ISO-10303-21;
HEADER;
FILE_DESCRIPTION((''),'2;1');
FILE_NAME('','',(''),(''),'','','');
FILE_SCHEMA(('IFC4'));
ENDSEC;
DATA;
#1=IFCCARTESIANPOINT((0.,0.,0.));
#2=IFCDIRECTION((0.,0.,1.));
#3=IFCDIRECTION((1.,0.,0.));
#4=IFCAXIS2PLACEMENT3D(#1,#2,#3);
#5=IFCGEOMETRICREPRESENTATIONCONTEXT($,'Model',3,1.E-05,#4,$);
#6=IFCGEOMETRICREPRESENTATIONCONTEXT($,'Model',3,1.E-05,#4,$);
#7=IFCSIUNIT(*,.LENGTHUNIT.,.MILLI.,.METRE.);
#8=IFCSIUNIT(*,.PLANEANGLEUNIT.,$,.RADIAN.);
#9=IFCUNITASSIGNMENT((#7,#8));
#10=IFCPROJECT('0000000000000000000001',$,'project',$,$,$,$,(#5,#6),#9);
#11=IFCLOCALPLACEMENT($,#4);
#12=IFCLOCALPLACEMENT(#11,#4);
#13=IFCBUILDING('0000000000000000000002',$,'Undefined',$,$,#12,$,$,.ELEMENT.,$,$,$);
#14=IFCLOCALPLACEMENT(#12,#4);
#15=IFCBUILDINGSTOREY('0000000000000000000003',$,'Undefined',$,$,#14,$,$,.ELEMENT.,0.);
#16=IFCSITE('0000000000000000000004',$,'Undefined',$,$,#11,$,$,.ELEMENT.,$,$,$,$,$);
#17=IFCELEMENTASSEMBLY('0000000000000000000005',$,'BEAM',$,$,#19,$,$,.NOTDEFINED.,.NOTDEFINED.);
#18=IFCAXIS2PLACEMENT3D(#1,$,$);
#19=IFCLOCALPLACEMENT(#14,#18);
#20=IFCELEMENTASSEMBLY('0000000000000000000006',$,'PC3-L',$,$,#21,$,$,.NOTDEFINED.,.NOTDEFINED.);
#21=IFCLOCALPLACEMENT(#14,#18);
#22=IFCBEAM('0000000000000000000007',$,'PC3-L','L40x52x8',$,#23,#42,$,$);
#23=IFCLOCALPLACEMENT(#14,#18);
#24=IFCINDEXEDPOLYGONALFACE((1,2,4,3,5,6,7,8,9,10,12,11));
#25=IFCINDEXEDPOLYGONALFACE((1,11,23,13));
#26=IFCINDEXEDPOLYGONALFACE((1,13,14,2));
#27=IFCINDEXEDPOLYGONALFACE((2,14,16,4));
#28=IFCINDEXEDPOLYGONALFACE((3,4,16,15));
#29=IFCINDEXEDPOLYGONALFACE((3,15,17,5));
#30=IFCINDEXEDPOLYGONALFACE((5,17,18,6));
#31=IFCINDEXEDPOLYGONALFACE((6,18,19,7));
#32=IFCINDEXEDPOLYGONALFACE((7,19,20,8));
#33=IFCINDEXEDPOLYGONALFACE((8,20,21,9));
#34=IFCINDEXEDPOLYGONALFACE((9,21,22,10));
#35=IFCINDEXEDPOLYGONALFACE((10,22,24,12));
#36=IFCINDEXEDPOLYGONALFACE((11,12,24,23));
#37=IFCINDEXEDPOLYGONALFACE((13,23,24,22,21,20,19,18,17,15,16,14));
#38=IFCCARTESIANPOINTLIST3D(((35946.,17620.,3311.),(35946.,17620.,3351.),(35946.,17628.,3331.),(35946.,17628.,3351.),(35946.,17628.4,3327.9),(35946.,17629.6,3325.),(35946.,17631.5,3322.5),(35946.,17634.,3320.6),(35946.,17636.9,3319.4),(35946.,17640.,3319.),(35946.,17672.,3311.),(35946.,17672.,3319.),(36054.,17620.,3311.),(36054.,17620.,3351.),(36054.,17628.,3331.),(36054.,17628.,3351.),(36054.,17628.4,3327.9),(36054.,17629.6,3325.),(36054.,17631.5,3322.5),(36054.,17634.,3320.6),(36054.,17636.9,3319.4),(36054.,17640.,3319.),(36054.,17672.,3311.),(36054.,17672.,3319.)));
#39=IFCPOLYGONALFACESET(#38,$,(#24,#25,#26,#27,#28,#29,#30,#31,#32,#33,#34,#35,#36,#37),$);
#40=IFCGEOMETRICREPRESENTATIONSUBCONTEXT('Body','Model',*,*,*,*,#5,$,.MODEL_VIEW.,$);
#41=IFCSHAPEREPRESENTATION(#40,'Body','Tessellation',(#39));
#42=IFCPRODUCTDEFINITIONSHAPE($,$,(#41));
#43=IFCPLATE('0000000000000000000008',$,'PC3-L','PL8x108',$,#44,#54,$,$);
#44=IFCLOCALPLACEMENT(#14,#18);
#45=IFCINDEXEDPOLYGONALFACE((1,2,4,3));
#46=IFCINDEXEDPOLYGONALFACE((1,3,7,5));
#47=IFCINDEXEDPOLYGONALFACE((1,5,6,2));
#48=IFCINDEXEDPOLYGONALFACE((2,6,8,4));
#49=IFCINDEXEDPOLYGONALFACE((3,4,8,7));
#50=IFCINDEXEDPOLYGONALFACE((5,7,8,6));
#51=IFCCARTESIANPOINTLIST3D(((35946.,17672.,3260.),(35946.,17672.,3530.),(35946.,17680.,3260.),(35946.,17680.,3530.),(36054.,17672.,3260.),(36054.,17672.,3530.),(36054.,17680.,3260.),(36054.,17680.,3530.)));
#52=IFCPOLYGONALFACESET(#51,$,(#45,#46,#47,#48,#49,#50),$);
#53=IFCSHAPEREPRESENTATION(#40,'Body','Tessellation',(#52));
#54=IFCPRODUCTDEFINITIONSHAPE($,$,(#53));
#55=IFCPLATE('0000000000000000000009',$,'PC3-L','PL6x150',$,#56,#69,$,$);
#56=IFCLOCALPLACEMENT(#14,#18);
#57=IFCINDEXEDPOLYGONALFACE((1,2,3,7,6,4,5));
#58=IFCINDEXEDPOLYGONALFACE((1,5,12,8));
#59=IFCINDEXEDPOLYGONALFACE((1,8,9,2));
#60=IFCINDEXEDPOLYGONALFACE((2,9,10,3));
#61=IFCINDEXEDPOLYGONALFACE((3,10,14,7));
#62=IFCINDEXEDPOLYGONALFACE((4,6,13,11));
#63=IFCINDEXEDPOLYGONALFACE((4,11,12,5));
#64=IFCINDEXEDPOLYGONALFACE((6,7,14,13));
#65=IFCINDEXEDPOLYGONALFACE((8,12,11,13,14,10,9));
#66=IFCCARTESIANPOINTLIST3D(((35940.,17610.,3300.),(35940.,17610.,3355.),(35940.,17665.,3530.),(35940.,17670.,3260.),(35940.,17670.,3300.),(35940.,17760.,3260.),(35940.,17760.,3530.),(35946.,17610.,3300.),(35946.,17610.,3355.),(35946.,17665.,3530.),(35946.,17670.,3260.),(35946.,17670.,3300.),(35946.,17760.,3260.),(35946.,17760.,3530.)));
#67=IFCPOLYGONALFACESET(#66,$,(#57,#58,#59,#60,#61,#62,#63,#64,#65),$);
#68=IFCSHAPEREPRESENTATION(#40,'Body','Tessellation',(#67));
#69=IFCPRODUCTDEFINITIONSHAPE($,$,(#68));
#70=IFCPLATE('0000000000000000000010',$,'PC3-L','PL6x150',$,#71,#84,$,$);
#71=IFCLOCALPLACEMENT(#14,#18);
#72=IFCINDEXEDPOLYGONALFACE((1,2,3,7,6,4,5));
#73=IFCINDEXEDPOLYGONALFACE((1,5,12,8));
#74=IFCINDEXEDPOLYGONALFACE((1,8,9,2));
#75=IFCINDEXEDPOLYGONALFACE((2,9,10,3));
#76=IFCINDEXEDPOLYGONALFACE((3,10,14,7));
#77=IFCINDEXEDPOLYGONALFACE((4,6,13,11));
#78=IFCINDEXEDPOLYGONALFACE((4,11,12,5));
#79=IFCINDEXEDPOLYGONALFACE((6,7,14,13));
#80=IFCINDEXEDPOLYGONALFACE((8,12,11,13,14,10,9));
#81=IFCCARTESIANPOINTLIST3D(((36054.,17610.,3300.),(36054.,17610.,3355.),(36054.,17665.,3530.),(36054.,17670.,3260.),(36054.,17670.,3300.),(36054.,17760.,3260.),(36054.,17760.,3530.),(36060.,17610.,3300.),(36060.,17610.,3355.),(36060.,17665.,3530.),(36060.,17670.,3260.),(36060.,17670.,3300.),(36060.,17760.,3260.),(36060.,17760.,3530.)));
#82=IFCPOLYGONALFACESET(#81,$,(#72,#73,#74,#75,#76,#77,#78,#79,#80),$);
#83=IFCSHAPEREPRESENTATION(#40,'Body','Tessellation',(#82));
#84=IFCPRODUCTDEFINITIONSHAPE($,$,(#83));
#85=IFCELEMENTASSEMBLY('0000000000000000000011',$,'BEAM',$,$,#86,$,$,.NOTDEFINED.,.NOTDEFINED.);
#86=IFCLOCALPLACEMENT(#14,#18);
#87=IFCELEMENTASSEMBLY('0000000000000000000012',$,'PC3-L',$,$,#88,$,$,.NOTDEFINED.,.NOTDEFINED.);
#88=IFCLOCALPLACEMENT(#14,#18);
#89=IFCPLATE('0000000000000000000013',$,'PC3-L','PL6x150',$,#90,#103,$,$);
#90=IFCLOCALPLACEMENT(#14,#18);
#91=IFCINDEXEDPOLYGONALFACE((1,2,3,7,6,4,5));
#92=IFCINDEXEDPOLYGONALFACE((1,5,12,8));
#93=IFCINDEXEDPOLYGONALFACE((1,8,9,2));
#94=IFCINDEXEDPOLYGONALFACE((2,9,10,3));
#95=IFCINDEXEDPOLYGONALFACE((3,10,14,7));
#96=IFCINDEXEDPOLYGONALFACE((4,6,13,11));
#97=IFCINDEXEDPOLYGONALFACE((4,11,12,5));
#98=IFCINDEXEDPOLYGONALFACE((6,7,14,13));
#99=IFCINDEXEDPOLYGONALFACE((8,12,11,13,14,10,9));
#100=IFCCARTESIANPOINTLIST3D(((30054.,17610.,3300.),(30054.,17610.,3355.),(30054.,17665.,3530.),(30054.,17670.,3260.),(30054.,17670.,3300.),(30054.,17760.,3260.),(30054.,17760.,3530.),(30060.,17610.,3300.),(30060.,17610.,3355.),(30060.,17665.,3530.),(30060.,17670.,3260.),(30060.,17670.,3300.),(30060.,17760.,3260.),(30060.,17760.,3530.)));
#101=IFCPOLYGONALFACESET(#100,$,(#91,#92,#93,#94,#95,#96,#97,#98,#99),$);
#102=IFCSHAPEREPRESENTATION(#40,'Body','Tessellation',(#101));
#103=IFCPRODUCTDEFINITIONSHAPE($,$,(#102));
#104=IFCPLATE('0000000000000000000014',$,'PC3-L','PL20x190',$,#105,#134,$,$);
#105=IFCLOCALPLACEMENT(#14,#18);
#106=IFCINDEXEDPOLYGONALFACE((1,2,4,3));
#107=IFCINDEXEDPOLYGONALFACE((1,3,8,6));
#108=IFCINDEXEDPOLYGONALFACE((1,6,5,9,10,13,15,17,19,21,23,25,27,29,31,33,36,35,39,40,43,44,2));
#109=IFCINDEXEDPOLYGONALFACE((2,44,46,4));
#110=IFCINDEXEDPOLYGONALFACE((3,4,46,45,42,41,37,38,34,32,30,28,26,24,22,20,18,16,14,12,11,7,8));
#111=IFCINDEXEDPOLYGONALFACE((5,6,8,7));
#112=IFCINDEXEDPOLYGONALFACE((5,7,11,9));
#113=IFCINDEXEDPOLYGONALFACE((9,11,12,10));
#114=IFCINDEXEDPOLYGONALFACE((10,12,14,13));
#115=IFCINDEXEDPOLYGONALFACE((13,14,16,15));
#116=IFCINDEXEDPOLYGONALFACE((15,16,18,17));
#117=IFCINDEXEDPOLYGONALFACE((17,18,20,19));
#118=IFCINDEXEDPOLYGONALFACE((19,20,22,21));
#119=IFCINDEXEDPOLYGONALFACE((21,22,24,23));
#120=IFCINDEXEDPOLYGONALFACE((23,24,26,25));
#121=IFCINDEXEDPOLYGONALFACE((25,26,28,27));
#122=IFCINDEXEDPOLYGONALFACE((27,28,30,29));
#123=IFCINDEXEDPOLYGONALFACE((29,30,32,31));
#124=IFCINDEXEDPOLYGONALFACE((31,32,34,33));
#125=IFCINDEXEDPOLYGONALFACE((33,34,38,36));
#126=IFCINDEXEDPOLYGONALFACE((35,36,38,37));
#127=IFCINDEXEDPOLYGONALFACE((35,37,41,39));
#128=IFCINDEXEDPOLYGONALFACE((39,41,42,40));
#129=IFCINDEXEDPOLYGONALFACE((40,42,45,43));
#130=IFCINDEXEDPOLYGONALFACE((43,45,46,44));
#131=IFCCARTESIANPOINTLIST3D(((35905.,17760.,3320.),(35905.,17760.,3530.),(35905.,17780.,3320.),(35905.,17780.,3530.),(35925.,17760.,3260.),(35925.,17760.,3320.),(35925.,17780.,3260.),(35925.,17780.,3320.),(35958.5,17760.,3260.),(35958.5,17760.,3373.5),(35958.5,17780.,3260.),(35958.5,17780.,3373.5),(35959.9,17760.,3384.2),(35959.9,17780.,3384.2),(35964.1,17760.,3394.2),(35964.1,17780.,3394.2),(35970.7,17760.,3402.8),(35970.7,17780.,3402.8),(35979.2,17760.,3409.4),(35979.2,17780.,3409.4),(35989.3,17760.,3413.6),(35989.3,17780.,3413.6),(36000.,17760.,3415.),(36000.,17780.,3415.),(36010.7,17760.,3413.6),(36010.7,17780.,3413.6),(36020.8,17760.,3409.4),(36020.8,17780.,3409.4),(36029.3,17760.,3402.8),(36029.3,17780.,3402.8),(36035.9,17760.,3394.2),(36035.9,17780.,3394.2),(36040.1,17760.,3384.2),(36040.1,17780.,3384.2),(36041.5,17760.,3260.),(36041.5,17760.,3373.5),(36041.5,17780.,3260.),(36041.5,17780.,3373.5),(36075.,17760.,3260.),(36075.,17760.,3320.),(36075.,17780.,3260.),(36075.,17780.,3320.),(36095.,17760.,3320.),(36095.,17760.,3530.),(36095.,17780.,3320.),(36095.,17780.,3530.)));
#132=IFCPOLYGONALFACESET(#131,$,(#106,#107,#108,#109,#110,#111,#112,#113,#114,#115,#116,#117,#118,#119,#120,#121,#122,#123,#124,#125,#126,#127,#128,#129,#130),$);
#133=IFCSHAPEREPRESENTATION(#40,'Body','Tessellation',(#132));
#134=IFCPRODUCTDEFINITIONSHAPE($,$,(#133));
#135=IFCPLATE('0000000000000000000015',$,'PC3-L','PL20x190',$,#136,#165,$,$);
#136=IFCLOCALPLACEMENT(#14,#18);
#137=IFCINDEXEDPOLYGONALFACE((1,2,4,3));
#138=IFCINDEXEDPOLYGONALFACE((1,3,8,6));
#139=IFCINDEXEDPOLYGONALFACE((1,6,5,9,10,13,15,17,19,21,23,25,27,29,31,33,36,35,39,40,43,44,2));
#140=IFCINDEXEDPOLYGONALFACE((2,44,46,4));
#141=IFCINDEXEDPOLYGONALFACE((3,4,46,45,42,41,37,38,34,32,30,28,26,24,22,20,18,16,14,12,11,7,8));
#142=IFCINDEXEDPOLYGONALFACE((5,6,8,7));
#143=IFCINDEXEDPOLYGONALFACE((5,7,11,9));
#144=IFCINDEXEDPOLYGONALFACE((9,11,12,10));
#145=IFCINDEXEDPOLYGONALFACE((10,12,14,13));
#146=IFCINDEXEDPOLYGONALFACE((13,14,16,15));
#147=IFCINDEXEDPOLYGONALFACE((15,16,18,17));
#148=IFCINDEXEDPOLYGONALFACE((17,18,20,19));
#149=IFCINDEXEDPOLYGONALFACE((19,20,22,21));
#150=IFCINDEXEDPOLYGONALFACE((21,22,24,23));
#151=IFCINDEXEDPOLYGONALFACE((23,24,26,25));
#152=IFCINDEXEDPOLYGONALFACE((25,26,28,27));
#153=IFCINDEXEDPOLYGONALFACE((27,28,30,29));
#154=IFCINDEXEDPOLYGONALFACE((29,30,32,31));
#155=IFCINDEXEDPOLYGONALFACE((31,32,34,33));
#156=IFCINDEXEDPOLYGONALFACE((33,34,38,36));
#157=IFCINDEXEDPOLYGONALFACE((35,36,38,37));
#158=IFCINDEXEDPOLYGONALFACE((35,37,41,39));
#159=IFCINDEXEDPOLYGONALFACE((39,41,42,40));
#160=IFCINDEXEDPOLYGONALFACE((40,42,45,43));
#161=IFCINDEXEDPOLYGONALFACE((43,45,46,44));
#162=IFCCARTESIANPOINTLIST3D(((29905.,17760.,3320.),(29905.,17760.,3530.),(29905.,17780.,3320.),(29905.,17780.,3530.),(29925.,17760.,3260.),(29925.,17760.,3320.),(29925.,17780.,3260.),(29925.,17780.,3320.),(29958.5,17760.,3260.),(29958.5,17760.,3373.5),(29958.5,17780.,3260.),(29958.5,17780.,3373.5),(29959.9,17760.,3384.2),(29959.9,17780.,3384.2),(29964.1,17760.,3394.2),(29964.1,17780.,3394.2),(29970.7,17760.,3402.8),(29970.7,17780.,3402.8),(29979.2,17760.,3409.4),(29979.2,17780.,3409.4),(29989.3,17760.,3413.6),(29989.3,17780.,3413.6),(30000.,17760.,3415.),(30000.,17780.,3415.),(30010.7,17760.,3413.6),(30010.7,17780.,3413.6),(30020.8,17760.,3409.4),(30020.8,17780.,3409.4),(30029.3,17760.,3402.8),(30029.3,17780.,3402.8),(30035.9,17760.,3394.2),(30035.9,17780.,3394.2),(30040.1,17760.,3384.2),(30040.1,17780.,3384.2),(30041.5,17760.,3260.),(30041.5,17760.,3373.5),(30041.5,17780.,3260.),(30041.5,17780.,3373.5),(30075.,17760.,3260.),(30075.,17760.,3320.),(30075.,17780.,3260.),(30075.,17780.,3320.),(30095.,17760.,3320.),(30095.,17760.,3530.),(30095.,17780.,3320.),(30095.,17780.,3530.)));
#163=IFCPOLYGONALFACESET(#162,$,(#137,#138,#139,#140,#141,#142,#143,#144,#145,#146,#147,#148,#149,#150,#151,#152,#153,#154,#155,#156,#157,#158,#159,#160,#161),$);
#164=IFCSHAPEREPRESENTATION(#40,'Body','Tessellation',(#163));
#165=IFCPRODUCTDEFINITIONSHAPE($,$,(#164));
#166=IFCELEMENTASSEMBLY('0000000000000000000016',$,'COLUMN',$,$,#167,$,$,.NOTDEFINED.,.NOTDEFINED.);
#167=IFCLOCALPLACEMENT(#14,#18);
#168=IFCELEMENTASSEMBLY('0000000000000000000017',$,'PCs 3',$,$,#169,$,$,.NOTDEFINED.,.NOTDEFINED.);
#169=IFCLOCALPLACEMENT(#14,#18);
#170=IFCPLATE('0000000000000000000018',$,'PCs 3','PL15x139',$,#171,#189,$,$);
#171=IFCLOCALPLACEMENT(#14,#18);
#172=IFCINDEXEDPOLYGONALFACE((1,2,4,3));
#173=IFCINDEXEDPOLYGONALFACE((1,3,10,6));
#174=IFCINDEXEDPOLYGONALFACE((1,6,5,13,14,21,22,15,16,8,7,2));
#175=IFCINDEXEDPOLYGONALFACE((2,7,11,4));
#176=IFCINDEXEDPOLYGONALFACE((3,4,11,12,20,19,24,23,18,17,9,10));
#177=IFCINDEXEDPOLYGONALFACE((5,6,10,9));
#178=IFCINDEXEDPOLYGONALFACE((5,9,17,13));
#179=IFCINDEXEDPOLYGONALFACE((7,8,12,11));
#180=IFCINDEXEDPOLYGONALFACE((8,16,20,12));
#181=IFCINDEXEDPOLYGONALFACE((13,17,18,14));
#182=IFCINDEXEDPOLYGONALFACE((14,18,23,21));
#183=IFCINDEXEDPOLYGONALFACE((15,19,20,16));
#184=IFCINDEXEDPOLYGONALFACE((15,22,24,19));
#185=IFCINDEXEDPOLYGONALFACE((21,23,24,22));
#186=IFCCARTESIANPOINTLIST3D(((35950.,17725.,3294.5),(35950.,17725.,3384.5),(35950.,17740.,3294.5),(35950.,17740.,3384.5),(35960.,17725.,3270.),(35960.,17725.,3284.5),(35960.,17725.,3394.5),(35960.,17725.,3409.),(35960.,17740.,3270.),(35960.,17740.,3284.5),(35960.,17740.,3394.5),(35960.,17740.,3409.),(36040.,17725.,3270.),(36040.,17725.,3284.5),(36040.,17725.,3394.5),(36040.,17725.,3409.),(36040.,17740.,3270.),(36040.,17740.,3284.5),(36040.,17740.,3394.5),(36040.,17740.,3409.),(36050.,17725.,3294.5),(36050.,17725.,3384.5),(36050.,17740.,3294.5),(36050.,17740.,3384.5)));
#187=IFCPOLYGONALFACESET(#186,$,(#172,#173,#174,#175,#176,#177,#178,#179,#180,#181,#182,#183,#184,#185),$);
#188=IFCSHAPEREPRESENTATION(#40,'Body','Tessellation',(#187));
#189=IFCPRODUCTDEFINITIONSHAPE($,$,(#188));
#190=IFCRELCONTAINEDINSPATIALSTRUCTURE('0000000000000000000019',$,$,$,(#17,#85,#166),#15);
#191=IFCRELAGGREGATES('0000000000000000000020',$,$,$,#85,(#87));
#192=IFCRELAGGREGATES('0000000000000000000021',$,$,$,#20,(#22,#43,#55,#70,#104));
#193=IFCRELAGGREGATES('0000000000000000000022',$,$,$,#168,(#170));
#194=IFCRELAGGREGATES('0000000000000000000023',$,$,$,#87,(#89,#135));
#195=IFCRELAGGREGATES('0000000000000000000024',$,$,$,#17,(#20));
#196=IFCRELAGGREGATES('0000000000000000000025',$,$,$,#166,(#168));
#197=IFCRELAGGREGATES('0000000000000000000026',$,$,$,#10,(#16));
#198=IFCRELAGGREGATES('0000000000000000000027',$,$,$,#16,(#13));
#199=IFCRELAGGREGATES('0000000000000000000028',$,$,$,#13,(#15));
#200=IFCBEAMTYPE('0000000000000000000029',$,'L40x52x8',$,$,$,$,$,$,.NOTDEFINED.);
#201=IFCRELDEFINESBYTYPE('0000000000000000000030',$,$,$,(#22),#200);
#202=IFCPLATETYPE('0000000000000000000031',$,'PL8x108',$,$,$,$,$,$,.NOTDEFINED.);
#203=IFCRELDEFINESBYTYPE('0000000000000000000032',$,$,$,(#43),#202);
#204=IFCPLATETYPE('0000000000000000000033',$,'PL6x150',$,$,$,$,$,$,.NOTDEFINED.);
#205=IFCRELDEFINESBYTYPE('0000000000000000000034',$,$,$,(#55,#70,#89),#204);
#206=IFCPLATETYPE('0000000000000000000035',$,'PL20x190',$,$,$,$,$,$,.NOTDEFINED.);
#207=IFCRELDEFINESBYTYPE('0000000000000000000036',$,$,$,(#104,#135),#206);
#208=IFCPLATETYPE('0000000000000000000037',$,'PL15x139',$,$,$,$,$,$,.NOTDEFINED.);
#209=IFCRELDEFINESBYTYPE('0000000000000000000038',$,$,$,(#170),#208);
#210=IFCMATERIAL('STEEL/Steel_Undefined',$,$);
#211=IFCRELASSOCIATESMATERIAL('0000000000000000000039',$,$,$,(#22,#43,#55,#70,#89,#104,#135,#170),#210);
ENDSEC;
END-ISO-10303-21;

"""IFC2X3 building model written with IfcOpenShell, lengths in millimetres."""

from ifc_helpers import new_model, si_unit, frame, frame_2d, origin_with_axes, origin_2d_with_axis, place, context, subcontext, project, spatial, polyline, circle_curve, parameter, trimmed, segment, composite_curve, l_section, outline, extrude, material, type_object, element, aggregate, save


model = new_model("IFC2X3")

# Units and contexts
model_context_1 = context("Model", 3, precision=1e-05, world=origin_with_axes())
model_context_2 = context("Model", 3, precision=1e-05, world=origin_with_axes())
body_context = subcontext(model_context_1, "Body", "Model", "MODEL_VIEW")
ifc_project = project(units=[si_unit("LENGTHUNIT", "METRE", prefix="MILLI"), si_unit("PLANEANGLEUNIT", "RADIAN")], contexts=[model_context_1, model_context_2])

# Site, building, storey
site_placement = place(None, origin_with_axes())
site = spatial("IfcSite", under=ifc_project, at=site_placement, Name="Undefined", CompositionType="ELEMENT")
building_placement = place(site_placement, origin_with_axes())
building = spatial("IfcBuilding", under=site, at=building_placement, Name="Undefined", CompositionType="ELEMENT")
storey_placement = place(building_placement, origin_with_axes())
storey = spatial("IfcBuildingStorey", under=building, at=storey_placement, Name="Undefined", CompositionType="ELEMENT", Elevation=0.0)

# Element assemblies, beam, plates
assembly_1_placement = place(storey_placement, origin_with_axes())
assembly_1 = element("IfcElementAssembly", 1, at=assembly_1_placement, inside=storey, Name="BEAM", AssemblyPlace="NOTDEFINED", PredefinedType="NOTDEFINED")
assembly_2_placement = place(assembly_1_placement, origin_with_axes())
assembly_2 = element("IfcElementAssembly", 2, at=assembly_2_placement, Name="PC3-L", AssemblyPlace="NOTDEFINED", PredefinedType="NOTDEFINED")
ifc_material_1 = material(Name="STEEL/Steel_Undefined")
beam_type = type_object("IfcBeamType", Name="L40x52x8", PredefinedType="NOTDEFINED")
beam_placement = place(assembly_2_placement, frame((36054.0, 17646.0, 3331.0), z_axis=(0.0, 0.0, 1.0), x_axis=(-1.0, 0.0, 0.0)))
beam = element("IfcBeam", 3, at=beam_placement, type_object=beam_type, material=ifc_material_1, Name="PC3-L", Description="L40x52x8", context=body_context, shape_type="SweptSolid", body=[
    extrude(l_section(Depth=40.0, Width=52.0, Thickness=8.0, FilletRadius=12.0, at=origin_2d_with_axis()), frame((108.0, 0.0, 0.0), z_axis=(-1.0, 0.0, 0.0), x_axis=(0.0, -1.0, 0.0)), (0.0, 0.0, 1.0), 108.0),
])
plate_type_1 = type_object("IfcPlateType", Name="PL8x108", PredefinedType="NOTDEFINED")
plate_1_placement = place(assembly_2_placement, frame((36054.0, 17676.0, 3260.0), z_axis=(0.0, 1.0, 0.0), x_axis=(-1.0, 0.0, 0.0)))
plate_1 = element("IfcPlate", 4, at=plate_1_placement, type_object=plate_type_1, material=ifc_material_1, Name="PC3-L", Description="PL8x108", context=body_context, shape_type="SweptSolid", body=[
    extrude(outline(polyline([(0.0, 0.0), (108.0, 0.0), (108.0, 270.0), (0.0, 270.0), (0.0, 0.0)])), frame((0.0, 0.0, -4.0), z_axis=(0.0, 0.0, 1.0), x_axis=(1.0, 0.0, 0.0)), (0.0, 0.0, 1.0), 8.0),
])
plate_type_2 = type_object("IfcPlateType", Name="PL6x150", PredefinedType="NOTDEFINED")
plate_2_placement = place(assembly_2_placement, frame((35943.0, 17670.0, 3260.0), z_axis=(-1.0, 0.0, 0.0), x_axis=(0.0, 0.0, 1.0)))
plate_2 = element("IfcPlate", 5, at=plate_2_placement, type_object=plate_type_2, material=ifc_material_1, Name="PC3-L", Description="PL6x150", context=body_context, shape_type="SweptSolid", body=[
    extrude(outline(polyline([(0.0, 0.0), (40.0, 0.0), (40.0, -60.0), (95.0, -60.0), (270.0, -5.0), (270.0, 90.0), (0.0, 90.0), (0.0, 0.0)])), frame((0.0, 0.0, -3.0), z_axis=(0.0, 0.0, 1.0), x_axis=(1.0, 0.0, 0.0)), (0.0, 0.0, 1.0), 6.0),
])
plate_3_placement = place(assembly_2_placement, frame((36057.0, 17670.0, 3260.0), z_axis=(-1.0, 0.0, 0.0), x_axis=(0.0, 0.0, 1.0)))
plate_3 = element("IfcPlate", 6, at=plate_3_placement, type_object=plate_type_2, material=ifc_material_1, Name="PC3-L", Description="PL6x150", context=body_context, shape_type="SweptSolid", body=[
    extrude(outline(polyline([(0.0, 0.0), (40.0, 0.0), (40.0, -60.0), (95.0, -60.0), (270.0, -5.0), (270.0, 90.0), (0.0, 90.0), (0.0, 0.0)])), frame((0.0, 0.0, -3.0), z_axis=(0.0, 0.0, 1.0), x_axis=(1.0, 0.0, 0.0)), (0.0, 0.0, 1.0), 6.0),
])

# Element assemblies, plate
assembly_3_placement = place(storey_placement, origin_with_axes())
assembly_3 = element("IfcElementAssembly", 7, at=assembly_3_placement, inside=storey, Name="BEAM", AssemblyPlace="NOTDEFINED", PredefinedType="NOTDEFINED")
assembly_4_placement = place(assembly_3_placement, origin_with_axes())
assembly_4 = element("IfcElementAssembly", 8, at=assembly_4_placement, Name="PC3-L", AssemblyPlace="NOTDEFINED", PredefinedType="NOTDEFINED")
aggregate(assembly_3, [assembly_4])
plate_4_placement = place(assembly_4_placement, frame((30057.0, 17670.0, 3260.0), z_axis=(-1.0, 0.0, 0.0), x_axis=(0.0, 0.0, 1.0)))
plate_4 = element("IfcPlate", 9, at=plate_4_placement, type_object=plate_type_2, material=ifc_material_1, Name="PC3-L", Description="PL6x150", context=body_context, shape_type="SweptSolid", body=[
    extrude(outline(polyline([(0.0, 0.0), (40.0, 0.0), (40.0, -60.0), (95.0, -60.0), (270.0, -5.0), (270.0, 90.0), (0.0, 90.0), (0.0, 0.0)])), frame((0.0, 0.0, -3.0), z_axis=(0.0, 0.0, 1.0), x_axis=(1.0, 0.0, 0.0)), (0.0, 0.0, 1.0), 6.0),
])

# Plates
plate_type_3 = type_object("IfcPlateType", Name="PL20x190", PredefinedType="NOTDEFINED")
plate_5_placement = place(assembly_2_placement, frame((36095.0, 17770.0, 3260.0), z_axis=(0.0, 1.0, 0.0), x_axis=(-1.0, 0.0, 0.0)))
plate_5 = element("IfcPlate", 10, at=plate_5_placement, type_object=plate_type_3, material=ifc_material_1, Name="PC3-L", Description="PL20x190", context=body_context, shape_type="SweptSolid", body=[
    extrude(outline(composite_curve([segment(polyline([(0.0, 60.0), (20.0, 60.0), (20.0, 0.0), (53.5, 0.0), (53.5, 113.5)]), True, "CONTINUOUS"), segment(trimmed(circle_curve(frame_2d((95.0, 113.5), x_axis=(-1.0, 0.0)), 41.5), [parameter(0.0)], [parameter(4.712389)], False, "PARAMETER"), True, "CONTINUOUS"), segment(polyline([(95.0, 155.0), (95.0, 155.0)]), True, "CONTINUOUS"), segment(trimmed(circle_curve(frame_2d((95.0, 113.5), x_axis=(0.0, 1.0)), 41.5), [parameter(0.0)], [parameter(4.712389)], False, "PARAMETER"), True, "CONTINUOUS"), segment(polyline([(136.5, 113.5), (136.5, 0.0), (170.0, 0.0), (170.0, 60.0), (190.0, 60.0), (190.0, 270.0), (0.0, 270.0), (0.0, 60.0)]), True, "CONTINUOUS")], self_intersect=True)), frame((0.0, 0.0, -10.0), z_axis=(0.0, 0.0, 1.0), x_axis=(1.0, 0.0, 0.0)), (0.0, 0.0, 1.0), 20.0),
])
plate_6_placement = place(assembly_4_placement, frame((30095.0, 17770.0, 3260.0), z_axis=(0.0, 1.0, 0.0), x_axis=(-1.0, 0.0, 0.0)))
plate_6 = element("IfcPlate", 11, at=plate_6_placement, type_object=plate_type_3, material=ifc_material_1, Name="PC3-L", Description="PL20x190", context=body_context, shape_type="SweptSolid", body=[
    extrude(outline(composite_curve([segment(polyline([(0.0, 60.0), (20.0, 60.0), (20.0, 0.0), (53.5, 0.0), (53.5, 113.5)]), True, "CONTINUOUS"), segment(trimmed(circle_curve(frame_2d((95.0, 113.5), x_axis=(-1.0, 0.0)), 41.5), [parameter(0.0)], [parameter(4.712389)], False, "PARAMETER"), True, "CONTINUOUS"), segment(polyline([(95.0, 155.0), (95.0, 155.0)]), True, "CONTINUOUS"), segment(trimmed(circle_curve(frame_2d((95.0, 113.5), x_axis=(0.0, 1.0)), 41.5), [parameter(0.0)], [parameter(4.712389)], False, "PARAMETER"), True, "CONTINUOUS"), segment(polyline([(136.5, 113.5), (136.5, 0.0), (170.0, 0.0), (170.0, 60.0), (190.0, 60.0), (190.0, 270.0), (0.0, 270.0), (0.0, 60.0)]), True, "CONTINUOUS")], self_intersect=True)), frame((0.0, 0.0, -10.0), z_axis=(0.0, 0.0, 1.0), x_axis=(1.0, 0.0, 0.0)), (0.0, 0.0, 1.0), 20.0),
])

# Element assemblies, plate
assembly_5_placement = place(storey_placement, origin_with_axes())
assembly_5 = element("IfcElementAssembly", 12, at=assembly_5_placement, inside=storey, Name="COLUMN", AssemblyPlace="NOTDEFINED", PredefinedType="NOTDEFINED")
assembly_6_placement = place(assembly_5_placement, origin_with_axes())
assembly_6 = element("IfcElementAssembly", 13, at=assembly_6_placement, Name="PCs 3", AssemblyPlace="NOTDEFINED", PredefinedType="NOTDEFINED")
plate_type_4 = type_object("IfcPlateType", Name="PL15x139", PredefinedType="NOTDEFINED")
plate_7_placement = place(assembly_6_placement, frame((35960.0, 17732.5, 3409.0), z_axis=(0.0, -1.0, 0.0), x_axis=(0.0, 0.0, -1.0)))
plate_7 = element("IfcPlate", 14, at=plate_7_placement, type_object=plate_type_4, material=ifc_material_1, Name="PCs 3", Description="PL15x139", context=body_context, shape_type="SweptSolid", body=[
    extrude(outline(polyline([(0.0, 0.0), (14.5, 0.0), (24.5, -10.0), (114.5, -10.0), (124.5, 0.0), (139.0, 0.0), (139.0, 80.0), (124.5, 80.0), (114.5, 90.0), (24.5, 90.0), (14.5, 80.0), (0.0, 80.0), (0.0, 0.0)])), frame((0.0, 0.0, -7.5), z_axis=(0.0, 0.0, 1.0), x_axis=(1.0, 0.0, 0.0)), (0.0, 0.0, 1.0), 15.0),
])

aggregate(assembly_2, [beam, plate_1, plate_2, plate_3, plate_5])
aggregate(assembly_6, [plate_7])
aggregate(assembly_4, [plate_4, plate_6])

aggregate(assembly_1, [assembly_2])

aggregate(assembly_5, [assembly_6])

save(model, "model.ifc")
